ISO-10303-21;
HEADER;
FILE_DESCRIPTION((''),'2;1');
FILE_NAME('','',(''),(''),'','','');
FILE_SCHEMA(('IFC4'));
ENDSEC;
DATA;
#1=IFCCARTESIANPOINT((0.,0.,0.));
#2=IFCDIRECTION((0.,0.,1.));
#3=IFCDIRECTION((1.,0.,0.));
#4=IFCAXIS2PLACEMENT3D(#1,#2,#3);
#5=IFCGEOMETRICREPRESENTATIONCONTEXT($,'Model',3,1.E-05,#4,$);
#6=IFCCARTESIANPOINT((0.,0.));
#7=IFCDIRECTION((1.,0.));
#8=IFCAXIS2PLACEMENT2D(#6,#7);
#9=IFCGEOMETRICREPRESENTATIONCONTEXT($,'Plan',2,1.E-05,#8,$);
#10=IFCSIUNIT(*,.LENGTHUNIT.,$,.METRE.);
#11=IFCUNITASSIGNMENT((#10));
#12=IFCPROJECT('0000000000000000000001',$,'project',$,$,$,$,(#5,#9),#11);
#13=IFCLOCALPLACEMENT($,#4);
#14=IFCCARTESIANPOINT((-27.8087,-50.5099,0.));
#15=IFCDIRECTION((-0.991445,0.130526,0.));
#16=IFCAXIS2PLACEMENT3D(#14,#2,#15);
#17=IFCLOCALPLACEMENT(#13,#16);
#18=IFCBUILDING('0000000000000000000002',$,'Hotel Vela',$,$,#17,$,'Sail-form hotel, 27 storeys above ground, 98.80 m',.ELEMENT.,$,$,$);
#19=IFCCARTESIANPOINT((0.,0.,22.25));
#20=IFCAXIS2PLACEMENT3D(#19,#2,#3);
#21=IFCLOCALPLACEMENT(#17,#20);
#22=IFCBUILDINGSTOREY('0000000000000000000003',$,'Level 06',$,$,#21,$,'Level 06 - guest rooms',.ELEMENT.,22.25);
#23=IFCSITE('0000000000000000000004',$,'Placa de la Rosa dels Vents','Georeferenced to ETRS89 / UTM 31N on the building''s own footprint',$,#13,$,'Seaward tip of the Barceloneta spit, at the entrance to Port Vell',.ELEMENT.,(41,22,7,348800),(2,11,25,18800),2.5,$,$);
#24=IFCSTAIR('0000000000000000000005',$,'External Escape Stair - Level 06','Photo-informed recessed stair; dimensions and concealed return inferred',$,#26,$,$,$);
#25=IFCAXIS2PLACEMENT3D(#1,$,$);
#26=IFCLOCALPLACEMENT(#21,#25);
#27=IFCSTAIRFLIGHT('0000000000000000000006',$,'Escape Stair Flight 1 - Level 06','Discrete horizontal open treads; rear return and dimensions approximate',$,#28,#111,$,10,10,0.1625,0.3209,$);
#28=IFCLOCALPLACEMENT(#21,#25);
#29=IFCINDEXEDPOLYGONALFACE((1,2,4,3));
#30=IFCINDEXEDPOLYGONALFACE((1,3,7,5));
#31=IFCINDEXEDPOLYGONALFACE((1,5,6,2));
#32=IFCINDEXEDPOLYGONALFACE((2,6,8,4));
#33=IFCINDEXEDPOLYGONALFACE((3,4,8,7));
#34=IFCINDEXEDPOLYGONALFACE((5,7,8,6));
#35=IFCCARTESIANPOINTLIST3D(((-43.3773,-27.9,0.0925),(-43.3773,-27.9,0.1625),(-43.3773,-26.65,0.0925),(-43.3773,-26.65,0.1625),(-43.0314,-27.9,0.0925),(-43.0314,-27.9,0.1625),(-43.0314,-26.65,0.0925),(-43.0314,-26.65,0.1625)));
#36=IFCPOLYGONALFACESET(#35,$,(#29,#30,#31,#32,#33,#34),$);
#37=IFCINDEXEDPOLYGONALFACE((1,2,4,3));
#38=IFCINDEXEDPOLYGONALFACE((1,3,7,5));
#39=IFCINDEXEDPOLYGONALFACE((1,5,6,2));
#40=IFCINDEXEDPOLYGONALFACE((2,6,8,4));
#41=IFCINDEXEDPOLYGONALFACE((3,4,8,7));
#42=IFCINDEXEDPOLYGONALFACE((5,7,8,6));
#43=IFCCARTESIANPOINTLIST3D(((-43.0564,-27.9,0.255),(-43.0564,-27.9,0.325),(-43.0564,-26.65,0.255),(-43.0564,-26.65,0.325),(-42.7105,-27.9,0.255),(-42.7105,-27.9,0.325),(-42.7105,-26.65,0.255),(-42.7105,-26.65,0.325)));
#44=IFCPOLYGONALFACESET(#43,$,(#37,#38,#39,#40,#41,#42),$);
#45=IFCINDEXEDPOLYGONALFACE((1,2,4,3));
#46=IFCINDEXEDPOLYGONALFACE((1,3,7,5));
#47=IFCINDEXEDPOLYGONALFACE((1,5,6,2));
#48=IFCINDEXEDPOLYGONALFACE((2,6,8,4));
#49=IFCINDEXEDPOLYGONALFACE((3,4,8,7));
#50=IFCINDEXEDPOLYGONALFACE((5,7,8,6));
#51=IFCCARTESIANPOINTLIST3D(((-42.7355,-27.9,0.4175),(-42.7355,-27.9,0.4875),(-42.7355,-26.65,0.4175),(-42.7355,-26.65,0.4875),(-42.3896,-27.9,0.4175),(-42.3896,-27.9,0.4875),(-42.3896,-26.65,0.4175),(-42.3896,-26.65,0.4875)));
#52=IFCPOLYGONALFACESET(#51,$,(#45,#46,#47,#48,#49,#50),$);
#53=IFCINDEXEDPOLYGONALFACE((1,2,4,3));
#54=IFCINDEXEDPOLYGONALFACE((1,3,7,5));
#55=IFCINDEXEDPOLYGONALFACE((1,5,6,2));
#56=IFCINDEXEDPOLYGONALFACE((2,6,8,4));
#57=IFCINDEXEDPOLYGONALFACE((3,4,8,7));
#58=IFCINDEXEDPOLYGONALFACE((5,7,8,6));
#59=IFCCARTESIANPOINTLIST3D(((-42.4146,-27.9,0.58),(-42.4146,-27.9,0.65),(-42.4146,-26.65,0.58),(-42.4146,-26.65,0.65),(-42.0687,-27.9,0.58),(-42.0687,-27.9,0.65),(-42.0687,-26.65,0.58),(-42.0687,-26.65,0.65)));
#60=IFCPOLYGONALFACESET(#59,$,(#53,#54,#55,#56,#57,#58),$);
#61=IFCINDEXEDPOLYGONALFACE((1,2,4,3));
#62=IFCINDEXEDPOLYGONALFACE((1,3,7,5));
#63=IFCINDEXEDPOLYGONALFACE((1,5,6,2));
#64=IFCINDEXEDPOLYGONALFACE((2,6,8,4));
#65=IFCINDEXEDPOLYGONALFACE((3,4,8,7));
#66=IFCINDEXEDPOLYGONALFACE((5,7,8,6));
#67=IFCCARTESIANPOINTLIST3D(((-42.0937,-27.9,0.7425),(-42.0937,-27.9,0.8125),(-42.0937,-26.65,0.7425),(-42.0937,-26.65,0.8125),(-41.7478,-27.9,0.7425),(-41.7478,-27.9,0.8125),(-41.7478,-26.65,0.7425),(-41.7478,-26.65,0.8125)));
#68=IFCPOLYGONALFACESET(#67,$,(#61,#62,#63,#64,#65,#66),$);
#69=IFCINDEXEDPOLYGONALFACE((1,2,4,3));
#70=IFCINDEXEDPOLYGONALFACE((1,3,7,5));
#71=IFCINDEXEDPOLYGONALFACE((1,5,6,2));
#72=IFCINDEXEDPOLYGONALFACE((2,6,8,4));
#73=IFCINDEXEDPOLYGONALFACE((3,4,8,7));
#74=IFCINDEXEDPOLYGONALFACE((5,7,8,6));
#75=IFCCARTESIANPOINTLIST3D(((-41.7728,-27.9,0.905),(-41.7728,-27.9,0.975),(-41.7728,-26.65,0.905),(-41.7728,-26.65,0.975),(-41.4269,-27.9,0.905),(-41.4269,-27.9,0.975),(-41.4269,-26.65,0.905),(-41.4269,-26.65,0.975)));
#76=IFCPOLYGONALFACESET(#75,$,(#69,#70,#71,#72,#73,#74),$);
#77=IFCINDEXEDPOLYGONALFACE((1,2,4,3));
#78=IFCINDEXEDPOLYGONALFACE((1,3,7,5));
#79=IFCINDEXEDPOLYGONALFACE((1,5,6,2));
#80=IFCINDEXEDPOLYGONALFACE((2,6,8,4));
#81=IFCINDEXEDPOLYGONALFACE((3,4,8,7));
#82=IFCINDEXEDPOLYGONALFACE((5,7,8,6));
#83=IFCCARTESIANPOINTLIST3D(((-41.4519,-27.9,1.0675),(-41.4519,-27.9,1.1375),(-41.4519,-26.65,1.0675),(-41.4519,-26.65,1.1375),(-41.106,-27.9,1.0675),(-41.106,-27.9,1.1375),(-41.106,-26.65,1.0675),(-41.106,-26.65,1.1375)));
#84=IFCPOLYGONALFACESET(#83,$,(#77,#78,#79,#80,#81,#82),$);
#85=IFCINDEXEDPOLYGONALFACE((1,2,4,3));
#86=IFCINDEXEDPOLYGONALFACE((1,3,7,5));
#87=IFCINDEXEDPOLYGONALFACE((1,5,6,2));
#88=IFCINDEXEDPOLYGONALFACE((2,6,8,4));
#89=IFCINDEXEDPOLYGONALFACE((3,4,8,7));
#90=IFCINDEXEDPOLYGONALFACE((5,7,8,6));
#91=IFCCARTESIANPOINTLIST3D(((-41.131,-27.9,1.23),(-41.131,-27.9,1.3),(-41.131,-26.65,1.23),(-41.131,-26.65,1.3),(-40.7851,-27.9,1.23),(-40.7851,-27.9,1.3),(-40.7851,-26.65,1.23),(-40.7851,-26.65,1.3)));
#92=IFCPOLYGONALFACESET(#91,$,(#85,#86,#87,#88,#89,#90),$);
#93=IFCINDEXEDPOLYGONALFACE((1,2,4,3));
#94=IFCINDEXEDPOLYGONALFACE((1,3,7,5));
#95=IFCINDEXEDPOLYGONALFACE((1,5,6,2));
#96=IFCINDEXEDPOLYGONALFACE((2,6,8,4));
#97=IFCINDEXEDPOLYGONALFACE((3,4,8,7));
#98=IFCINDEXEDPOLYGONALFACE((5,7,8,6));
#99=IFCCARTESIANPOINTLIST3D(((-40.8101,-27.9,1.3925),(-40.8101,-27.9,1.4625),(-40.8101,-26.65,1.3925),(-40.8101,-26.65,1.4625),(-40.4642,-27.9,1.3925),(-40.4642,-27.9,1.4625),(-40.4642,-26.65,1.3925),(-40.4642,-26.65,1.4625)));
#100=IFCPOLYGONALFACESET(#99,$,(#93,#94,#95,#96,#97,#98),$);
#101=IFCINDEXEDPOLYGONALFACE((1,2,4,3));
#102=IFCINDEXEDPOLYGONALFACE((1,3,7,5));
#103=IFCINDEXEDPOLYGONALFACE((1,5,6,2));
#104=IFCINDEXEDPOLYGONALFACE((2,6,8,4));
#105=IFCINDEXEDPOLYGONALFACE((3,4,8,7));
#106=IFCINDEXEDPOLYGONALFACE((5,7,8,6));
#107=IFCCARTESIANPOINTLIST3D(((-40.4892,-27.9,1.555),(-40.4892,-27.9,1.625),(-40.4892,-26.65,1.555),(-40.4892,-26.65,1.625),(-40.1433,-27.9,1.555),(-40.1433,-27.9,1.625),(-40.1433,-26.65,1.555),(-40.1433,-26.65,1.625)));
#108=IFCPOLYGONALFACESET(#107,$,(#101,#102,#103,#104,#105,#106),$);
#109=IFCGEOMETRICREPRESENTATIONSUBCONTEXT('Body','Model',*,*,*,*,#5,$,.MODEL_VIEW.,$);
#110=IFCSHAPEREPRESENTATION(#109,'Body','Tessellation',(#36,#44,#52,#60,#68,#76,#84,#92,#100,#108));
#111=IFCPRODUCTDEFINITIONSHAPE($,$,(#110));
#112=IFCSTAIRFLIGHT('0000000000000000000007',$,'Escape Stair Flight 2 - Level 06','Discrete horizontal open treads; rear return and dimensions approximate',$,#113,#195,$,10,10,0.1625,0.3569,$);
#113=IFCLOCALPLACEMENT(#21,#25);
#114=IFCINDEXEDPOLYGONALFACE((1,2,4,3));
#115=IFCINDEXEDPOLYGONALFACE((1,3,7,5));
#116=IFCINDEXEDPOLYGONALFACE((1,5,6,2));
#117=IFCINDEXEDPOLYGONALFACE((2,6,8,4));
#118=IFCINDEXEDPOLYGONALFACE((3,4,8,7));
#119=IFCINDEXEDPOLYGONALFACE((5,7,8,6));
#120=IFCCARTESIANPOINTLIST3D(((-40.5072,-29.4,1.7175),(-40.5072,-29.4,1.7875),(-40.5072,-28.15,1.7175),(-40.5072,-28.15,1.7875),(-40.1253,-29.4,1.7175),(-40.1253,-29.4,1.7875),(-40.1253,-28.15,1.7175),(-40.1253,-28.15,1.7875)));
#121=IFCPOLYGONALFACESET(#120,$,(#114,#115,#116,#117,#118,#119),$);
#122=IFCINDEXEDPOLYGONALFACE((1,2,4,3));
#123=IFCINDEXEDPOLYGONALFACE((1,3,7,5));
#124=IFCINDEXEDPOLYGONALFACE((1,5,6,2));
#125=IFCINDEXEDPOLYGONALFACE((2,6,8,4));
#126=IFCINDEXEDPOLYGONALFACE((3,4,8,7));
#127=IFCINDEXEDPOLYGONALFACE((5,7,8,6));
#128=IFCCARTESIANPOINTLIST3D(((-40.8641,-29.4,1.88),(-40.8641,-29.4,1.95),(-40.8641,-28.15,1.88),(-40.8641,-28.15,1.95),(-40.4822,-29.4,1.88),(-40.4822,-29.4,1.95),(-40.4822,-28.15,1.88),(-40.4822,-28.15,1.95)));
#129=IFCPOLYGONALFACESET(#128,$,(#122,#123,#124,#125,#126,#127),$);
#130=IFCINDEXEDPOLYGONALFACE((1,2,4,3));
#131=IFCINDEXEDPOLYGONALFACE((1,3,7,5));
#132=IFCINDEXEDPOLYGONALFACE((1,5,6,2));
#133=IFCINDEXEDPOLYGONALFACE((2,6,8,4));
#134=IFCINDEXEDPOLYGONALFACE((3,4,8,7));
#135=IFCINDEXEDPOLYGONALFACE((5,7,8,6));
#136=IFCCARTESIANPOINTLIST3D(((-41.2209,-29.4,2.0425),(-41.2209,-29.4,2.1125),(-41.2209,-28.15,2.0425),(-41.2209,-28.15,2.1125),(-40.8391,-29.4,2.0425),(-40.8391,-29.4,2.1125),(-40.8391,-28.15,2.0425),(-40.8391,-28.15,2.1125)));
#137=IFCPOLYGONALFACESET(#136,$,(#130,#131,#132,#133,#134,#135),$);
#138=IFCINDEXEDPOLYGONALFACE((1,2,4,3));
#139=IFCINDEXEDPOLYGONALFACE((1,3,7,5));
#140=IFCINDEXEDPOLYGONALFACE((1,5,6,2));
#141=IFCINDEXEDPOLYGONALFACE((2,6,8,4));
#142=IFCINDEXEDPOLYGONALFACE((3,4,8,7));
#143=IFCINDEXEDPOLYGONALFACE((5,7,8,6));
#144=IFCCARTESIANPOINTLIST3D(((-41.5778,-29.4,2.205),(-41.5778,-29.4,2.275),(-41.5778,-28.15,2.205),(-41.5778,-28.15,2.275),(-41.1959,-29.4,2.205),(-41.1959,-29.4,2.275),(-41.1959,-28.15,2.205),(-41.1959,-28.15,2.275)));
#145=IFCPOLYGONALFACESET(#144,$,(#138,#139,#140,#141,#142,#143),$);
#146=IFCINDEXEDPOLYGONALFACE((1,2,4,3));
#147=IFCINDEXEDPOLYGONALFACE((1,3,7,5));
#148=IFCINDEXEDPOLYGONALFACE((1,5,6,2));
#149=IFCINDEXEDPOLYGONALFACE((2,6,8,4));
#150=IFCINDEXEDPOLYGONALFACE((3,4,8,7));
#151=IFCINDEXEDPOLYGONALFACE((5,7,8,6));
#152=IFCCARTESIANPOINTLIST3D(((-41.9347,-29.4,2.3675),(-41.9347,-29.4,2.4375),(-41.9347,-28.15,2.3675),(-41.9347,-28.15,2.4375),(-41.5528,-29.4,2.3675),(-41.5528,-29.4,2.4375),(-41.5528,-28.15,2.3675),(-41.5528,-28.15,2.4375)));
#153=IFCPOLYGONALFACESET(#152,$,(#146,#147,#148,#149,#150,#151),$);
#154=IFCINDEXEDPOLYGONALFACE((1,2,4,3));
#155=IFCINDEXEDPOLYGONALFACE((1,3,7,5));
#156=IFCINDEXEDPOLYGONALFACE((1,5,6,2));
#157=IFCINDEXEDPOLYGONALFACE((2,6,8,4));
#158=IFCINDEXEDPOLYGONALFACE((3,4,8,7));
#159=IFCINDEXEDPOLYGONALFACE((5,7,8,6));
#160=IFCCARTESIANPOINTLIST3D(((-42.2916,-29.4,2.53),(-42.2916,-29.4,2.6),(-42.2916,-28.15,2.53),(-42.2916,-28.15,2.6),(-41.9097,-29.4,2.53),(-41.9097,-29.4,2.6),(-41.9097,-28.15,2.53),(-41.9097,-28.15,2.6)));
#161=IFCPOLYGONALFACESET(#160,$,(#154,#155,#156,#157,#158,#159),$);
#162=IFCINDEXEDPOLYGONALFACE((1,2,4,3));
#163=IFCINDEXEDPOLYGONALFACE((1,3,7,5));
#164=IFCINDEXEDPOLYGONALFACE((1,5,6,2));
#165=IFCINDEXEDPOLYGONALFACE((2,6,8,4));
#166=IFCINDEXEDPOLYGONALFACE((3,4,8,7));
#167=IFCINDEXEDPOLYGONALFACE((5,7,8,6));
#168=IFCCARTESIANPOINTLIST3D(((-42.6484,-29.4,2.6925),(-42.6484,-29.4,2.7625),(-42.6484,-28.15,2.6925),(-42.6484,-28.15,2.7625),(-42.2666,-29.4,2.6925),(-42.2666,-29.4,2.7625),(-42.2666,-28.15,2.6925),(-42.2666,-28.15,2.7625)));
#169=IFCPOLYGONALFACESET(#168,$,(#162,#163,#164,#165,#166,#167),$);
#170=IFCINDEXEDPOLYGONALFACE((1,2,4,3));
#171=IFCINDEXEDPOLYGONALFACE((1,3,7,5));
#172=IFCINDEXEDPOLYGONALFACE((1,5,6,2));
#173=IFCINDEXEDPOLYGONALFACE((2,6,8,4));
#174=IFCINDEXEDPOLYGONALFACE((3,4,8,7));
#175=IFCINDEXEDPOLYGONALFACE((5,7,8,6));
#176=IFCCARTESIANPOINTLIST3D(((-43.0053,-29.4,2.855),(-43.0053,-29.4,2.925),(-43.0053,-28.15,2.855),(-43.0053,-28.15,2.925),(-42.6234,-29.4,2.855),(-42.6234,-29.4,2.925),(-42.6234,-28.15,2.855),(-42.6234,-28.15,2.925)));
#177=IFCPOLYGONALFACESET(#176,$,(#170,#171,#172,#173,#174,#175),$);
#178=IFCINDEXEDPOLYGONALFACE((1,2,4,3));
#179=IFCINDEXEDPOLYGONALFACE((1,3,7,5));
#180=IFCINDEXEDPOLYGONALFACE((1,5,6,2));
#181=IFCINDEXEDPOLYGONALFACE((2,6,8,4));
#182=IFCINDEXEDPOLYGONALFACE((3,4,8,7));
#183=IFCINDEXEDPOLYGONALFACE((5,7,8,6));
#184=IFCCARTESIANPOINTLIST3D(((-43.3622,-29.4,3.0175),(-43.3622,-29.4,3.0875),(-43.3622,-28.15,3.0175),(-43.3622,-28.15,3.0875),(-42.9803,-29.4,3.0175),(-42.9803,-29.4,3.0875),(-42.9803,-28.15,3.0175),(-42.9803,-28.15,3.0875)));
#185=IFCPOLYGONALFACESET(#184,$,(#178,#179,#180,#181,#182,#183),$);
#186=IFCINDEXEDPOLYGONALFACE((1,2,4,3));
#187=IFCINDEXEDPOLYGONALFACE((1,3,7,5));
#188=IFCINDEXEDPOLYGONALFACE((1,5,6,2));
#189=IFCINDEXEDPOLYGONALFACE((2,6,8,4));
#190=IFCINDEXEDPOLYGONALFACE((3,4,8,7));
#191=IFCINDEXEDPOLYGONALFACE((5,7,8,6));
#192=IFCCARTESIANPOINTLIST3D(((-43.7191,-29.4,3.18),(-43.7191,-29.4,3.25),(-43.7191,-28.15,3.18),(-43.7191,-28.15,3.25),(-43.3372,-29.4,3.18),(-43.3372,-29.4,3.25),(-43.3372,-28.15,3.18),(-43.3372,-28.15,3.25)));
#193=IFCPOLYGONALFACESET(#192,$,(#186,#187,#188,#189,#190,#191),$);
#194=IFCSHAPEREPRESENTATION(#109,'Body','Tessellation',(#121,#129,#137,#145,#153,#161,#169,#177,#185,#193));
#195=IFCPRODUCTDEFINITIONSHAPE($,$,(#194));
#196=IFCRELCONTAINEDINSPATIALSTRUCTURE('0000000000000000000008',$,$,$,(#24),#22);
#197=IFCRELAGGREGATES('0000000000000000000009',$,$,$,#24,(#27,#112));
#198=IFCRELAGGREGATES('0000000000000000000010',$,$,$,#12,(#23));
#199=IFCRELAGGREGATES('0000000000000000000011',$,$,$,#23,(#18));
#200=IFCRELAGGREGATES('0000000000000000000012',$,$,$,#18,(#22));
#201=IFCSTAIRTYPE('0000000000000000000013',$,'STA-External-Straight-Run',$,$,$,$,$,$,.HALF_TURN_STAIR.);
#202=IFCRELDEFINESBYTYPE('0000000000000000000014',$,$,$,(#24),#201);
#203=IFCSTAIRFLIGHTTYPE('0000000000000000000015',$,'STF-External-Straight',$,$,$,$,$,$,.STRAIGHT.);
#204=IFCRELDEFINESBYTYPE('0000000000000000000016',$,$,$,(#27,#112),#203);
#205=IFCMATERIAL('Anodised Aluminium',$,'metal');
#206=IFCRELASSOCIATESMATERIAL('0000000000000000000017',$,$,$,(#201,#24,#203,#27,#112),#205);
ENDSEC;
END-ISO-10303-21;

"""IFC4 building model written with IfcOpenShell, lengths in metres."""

from ifc_helpers import new_model, si_unit, frame, origin_with_axes, origin_2d_with_axis, place, context, subcontext, project, spatial, line, indexed_curve, outline, extrude, material, type_object, element, aggregate, save


model = new_model("IFC4")

# Units and contexts
model_context = context("Model", 3, precision=1e-05, world=origin_with_axes())
plan_context = context("Plan", 2, precision=1e-05, world=origin_2d_with_axis())
body_context = subcontext(model_context, "Body", "Model", "MODEL_VIEW")
ifc_project = project(units=[si_unit("LENGTHUNIT", "METRE")], contexts=[model_context, plan_context])

# Site, building, storey
site_placement = place(None, origin_with_axes())
site = spatial("IfcSite", under=ifc_project, at=site_placement, Name="Placa de la Rosa dels Vents", Description="Georeferenced to ETRS89 / UTM 31N on the building's own footprint", LongName="Seaward tip of the Barceloneta spit, at the entrance to Port Vell", CompositionType="ELEMENT", RefLatitude=(41, 22, 7, 348800), RefLongitude=(2, 11, 25, 18800), RefElevation=2.5)
building_placement = place(site_placement, frame((-27.8087, -50.5099, 0.0), z_axis=(0.0, 0.0, 1.0), x_axis=(-0.991445, 0.130526, 0.0)))
building = spatial("IfcBuilding", under=site, at=building_placement, Name="Hotel Vela", LongName="Sail-form hotel, 27 storeys above ground, 98.80 m", CompositionType="ELEMENT")
storey_placement = place(building_placement, frame((0.0, 0.0, 22.25), z_axis=(0.0, 0.0, 1.0), x_axis=(1.0, 0.0, 0.0)))
storey = spatial("IfcBuildingStorey", under=building, at=storey_placement, Name="Level 06", LongName="Level 06 - guest rooms", CompositionType="ELEMENT", Elevation=22.25)

# Stair
ifc_material_1 = material(Name="Anodised Aluminium", Category="metal")
stair_type = type_object("IfcStairType", Name="STA-External-Straight-Run", PredefinedType="HALF_TURN_STAIR", material=ifc_material_1)
stair_placement = place(storey_placement, frame((0.0, 0.0, -22.25), z_axis=(0.0, 0.0, 1.0), x_axis=(1.0, 0.0, 0.0)))
stair = element("IfcStair", 1, at=stair_placement, inside=storey, type_object=stair_type, material=ifc_material_1, Name="External Escape Stair - Level 06", Description="Photo-informed recessed stair; dimensions and concealed return inferred")

# Stair flights
stair_flight_type = type_object("IfcStairFlightType", Name="STF-External-Straight", PredefinedType="STRAIGHT", material=ifc_material_1)
stair_flight_1_placement = place(stair_placement, origin_with_axes())
stair_flight_1 = element("IfcStairFlight", 2, at=stair_flight_1_placement, type_object=stair_flight_type, material=ifc_material_1, Name="Escape Stair Flight 1 - Level 06", Description="Discrete horizontal open treads; rear return and dimensions approximate", NumberOfRisers=10, NumberOfTreads=10, RiserHeight=0.1625, TreadLength=0.3209, context=body_context, shape_type="SweptSolid", body=[
    extrude(outline(indexed_curve([(0.0, 0.0), (0.3459, 0.0), (0.3459, 1.25), (0.0, 1.25)], segments=[line(1, 2, 3, 4, 1)])), frame((-43.3773, -27.9, 22.3425), z_axis=(0.0, 0.0, 1.0), x_axis=(1.0, 0.0, 0.0)), (0.0, 0.0, 1.0), 0.07),
    extrude(outline(indexed_curve([(0.0, 0.0), (0.3459, 0.0), (0.3459, 1.25), (0.0, 1.25)], segments=[line(1, 2, 3, 4, 1)])), frame((-43.0564, -27.9, 22.505), z_axis=(0.0, 0.0, 1.0), x_axis=(1.0, 0.0, 0.0)), (0.0, 0.0, 1.0), 0.07),
    extrude(outline(indexed_curve([(0.0, 0.0), (0.3459, 0.0), (0.3459, 1.25), (0.0, 1.25)], segments=[line(1, 2, 3, 4, 1)])), frame((-42.7355, -27.9, 22.6675), z_axis=(0.0, 0.0, 1.0), x_axis=(1.0, 0.0, 0.0)), (0.0, 0.0, 1.0), 0.07),
    extrude(outline(indexed_curve([(0.0, 0.0), (0.3459, 0.0), (0.3459, 1.25), (0.0, 1.25)], segments=[line(1, 2, 3, 4, 1)])), frame((-42.4146, -27.9, 22.83), z_axis=(0.0, 0.0, 1.0), x_axis=(1.0, 0.0, 0.0)), (0.0, 0.0, 1.0), 0.07),
    extrude(outline(indexed_curve([(0.0, 0.0), (0.3459, 0.0), (0.3459, 1.25), (0.0, 1.25)], segments=[line(1, 2, 3, 4, 1)])), frame((-42.0937, -27.9, 22.9925), z_axis=(0.0, 0.0, 1.0), x_axis=(1.0, 0.0, 0.0)), (0.0, 0.0, 1.0), 0.07),
    extrude(outline(indexed_curve([(0.0, 0.0), (0.3459, 0.0), (0.3459, 1.25), (0.0, 1.25)], segments=[line(1, 2, 3, 4, 1)])), frame((-41.7728, -27.9, 23.155), z_axis=(0.0, 0.0, 1.0), x_axis=(1.0, 0.0, 0.0)), (0.0, 0.0, 1.0), 0.07),
    extrude(outline(indexed_curve([(0.0, 0.0), (0.3459, 0.0), (0.3459, 1.25), (0.0, 1.25)], segments=[line(1, 2, 3, 4, 1)])), frame((-41.4519, -27.9, 23.3175), z_axis=(0.0, 0.0, 1.0), x_axis=(1.0, 0.0, 0.0)), (0.0, 0.0, 1.0), 0.07),
    extrude(outline(indexed_curve([(0.0, 0.0), (0.3459, 0.0), (0.3459, 1.25), (0.0, 1.25)], segments=[line(1, 2, 3, 4, 1)])), frame((-41.131, -27.9, 23.48), z_axis=(0.0, 0.0, 1.0), x_axis=(1.0, 0.0, 0.0)), (0.0, 0.0, 1.0), 0.07),
    extrude(outline(indexed_curve([(0.0, 0.0), (0.3459, 0.0), (0.3459, 1.25), (0.0, 1.25)], segments=[line(1, 2, 3, 4, 1)])), frame((-40.8101, -27.9, 23.6425), z_axis=(0.0, 0.0, 1.0), x_axis=(1.0, 0.0, 0.0)), (0.0, 0.0, 1.0), 0.07),
    extrude(outline(indexed_curve([(0.0, 0.0), (0.3459, 0.0), (0.3459, 1.25), (0.0, 1.25)], segments=[line(1, 2, 3, 4, 1)])), frame((-40.4892, -27.9, 23.805), z_axis=(0.0, 0.0, 1.0), x_axis=(1.0, 0.0, 0.0)), (0.0, 0.0, 1.0), 0.07),
])
stair_flight_2_placement = place(stair_placement, origin_with_axes())
stair_flight_2 = element("IfcStairFlight", 3, at=stair_flight_2_placement, type_object=stair_flight_type, material=ifc_material_1, Name="Escape Stair Flight 2 - Level 06", Description="Discrete horizontal open treads; rear return and dimensions approximate", NumberOfRisers=10, NumberOfTreads=10, RiserHeight=0.1625, TreadLength=0.3569, context=body_context, shape_type="SweptSolid", body=[
    extrude(outline(indexed_curve([(0.0, 0.0), (0.3819, 0.0), (0.3819, 1.25), (0.0, 1.25)], segments=[line(1, 2, 3, 4, 1)])), frame((-40.5072, -29.4, 23.9675), z_axis=(0.0, 0.0, 1.0), x_axis=(1.0, 0.0, 0.0)), (0.0, 0.0, 1.0), 0.07),
    extrude(outline(indexed_curve([(0.0, 0.0), (0.3819, 0.0), (0.3819, 1.25), (0.0, 1.25)], segments=[line(1, 2, 3, 4, 1)])), frame((-40.8641, -29.4, 24.13), z_axis=(0.0, 0.0, 1.0), x_axis=(1.0, 0.0, 0.0)), (0.0, 0.0, 1.0), 0.07),
    extrude(outline(indexed_curve([(0.0, 0.0), (0.3819, 0.0), (0.3819, 1.25), (0.0, 1.25)], segments=[line(1, 2, 3, 4, 1)])), frame((-41.2209, -29.4, 24.2925), z_axis=(0.0, 0.0, 1.0), x_axis=(1.0, 0.0, 0.0)), (0.0, 0.0, 1.0), 0.07),
    extrude(outline(indexed_curve([(0.0, 0.0), (0.3819, 0.0), (0.3819, 1.25), (0.0, 1.25)], segments=[line(1, 2, 3, 4, 1)])), frame((-41.5778, -29.4, 24.455), z_axis=(0.0, 0.0, 1.0), x_axis=(1.0, 0.0, 0.0)), (0.0, 0.0, 1.0), 0.07),
    extrude(outline(indexed_curve([(0.0, 0.0), (0.3819, 0.0), (0.3819, 1.25), (0.0, 1.25)], segments=[line(1, 2, 3, 4, 1)])), frame((-41.9347, -29.4, 24.6175), z_axis=(0.0, 0.0, 1.0), x_axis=(1.0, 0.0, 0.0)), (0.0, 0.0, 1.0), 0.07),
    extrude(outline(indexed_curve([(0.0, 0.0), (0.3819, 0.0), (0.3819, 1.25), (0.0, 1.25)], segments=[line(1, 2, 3, 4, 1)])), frame((-42.2916, -29.4, 24.78), z_axis=(0.0, 0.0, 1.0), x_axis=(1.0, 0.0, 0.0)), (0.0, 0.0, 1.0), 0.07),
    extrude(outline(indexed_curve([(0.0, 0.0), (0.3819, 0.0), (0.3819, 1.25), (0.0, 1.25)], segments=[line(1, 2, 3, 4, 1)])), frame((-42.6484, -29.4, 24.9425), z_axis=(0.0, 0.0, 1.0), x_axis=(1.0, 0.0, 0.0)), (0.0, 0.0, 1.0), 0.07),
    extrude(outline(indexed_curve([(0.0, 0.0), (0.3819, 0.0), (0.3819, 1.25), (0.0, 1.25)], segments=[line(1, 2, 3, 4, 1)])), frame((-43.0053, -29.4, 25.105), z_axis=(0.0, 0.0, 1.0), x_axis=(1.0, 0.0, 0.0)), (0.0, 0.0, 1.0), 0.07),
    extrude(outline(indexed_curve([(0.0, 0.0), (0.3819, 0.0), (0.3819, 1.25), (0.0, 1.25)], segments=[line(1, 2, 3, 4, 1)])), frame((-43.3622, -29.4, 25.2675), z_axis=(0.0, 0.0, 1.0), x_axis=(1.0, 0.0, 0.0)), (0.0, 0.0, 1.0), 0.07),
    extrude(outline(indexed_curve([(0.0, 0.0), (0.3819, 0.0), (0.3819, 1.25), (0.0, 1.25)], segments=[line(1, 2, 3, 4, 1)])), frame((-43.7191, -29.4, 25.43), z_axis=(0.0, 0.0, 1.0), x_axis=(1.0, 0.0, 0.0)), (0.0, 0.0, 1.0), 0.07),
])

aggregate(stair, [stair_flight_1, stair_flight_2])

save(model, "model.ifc")
